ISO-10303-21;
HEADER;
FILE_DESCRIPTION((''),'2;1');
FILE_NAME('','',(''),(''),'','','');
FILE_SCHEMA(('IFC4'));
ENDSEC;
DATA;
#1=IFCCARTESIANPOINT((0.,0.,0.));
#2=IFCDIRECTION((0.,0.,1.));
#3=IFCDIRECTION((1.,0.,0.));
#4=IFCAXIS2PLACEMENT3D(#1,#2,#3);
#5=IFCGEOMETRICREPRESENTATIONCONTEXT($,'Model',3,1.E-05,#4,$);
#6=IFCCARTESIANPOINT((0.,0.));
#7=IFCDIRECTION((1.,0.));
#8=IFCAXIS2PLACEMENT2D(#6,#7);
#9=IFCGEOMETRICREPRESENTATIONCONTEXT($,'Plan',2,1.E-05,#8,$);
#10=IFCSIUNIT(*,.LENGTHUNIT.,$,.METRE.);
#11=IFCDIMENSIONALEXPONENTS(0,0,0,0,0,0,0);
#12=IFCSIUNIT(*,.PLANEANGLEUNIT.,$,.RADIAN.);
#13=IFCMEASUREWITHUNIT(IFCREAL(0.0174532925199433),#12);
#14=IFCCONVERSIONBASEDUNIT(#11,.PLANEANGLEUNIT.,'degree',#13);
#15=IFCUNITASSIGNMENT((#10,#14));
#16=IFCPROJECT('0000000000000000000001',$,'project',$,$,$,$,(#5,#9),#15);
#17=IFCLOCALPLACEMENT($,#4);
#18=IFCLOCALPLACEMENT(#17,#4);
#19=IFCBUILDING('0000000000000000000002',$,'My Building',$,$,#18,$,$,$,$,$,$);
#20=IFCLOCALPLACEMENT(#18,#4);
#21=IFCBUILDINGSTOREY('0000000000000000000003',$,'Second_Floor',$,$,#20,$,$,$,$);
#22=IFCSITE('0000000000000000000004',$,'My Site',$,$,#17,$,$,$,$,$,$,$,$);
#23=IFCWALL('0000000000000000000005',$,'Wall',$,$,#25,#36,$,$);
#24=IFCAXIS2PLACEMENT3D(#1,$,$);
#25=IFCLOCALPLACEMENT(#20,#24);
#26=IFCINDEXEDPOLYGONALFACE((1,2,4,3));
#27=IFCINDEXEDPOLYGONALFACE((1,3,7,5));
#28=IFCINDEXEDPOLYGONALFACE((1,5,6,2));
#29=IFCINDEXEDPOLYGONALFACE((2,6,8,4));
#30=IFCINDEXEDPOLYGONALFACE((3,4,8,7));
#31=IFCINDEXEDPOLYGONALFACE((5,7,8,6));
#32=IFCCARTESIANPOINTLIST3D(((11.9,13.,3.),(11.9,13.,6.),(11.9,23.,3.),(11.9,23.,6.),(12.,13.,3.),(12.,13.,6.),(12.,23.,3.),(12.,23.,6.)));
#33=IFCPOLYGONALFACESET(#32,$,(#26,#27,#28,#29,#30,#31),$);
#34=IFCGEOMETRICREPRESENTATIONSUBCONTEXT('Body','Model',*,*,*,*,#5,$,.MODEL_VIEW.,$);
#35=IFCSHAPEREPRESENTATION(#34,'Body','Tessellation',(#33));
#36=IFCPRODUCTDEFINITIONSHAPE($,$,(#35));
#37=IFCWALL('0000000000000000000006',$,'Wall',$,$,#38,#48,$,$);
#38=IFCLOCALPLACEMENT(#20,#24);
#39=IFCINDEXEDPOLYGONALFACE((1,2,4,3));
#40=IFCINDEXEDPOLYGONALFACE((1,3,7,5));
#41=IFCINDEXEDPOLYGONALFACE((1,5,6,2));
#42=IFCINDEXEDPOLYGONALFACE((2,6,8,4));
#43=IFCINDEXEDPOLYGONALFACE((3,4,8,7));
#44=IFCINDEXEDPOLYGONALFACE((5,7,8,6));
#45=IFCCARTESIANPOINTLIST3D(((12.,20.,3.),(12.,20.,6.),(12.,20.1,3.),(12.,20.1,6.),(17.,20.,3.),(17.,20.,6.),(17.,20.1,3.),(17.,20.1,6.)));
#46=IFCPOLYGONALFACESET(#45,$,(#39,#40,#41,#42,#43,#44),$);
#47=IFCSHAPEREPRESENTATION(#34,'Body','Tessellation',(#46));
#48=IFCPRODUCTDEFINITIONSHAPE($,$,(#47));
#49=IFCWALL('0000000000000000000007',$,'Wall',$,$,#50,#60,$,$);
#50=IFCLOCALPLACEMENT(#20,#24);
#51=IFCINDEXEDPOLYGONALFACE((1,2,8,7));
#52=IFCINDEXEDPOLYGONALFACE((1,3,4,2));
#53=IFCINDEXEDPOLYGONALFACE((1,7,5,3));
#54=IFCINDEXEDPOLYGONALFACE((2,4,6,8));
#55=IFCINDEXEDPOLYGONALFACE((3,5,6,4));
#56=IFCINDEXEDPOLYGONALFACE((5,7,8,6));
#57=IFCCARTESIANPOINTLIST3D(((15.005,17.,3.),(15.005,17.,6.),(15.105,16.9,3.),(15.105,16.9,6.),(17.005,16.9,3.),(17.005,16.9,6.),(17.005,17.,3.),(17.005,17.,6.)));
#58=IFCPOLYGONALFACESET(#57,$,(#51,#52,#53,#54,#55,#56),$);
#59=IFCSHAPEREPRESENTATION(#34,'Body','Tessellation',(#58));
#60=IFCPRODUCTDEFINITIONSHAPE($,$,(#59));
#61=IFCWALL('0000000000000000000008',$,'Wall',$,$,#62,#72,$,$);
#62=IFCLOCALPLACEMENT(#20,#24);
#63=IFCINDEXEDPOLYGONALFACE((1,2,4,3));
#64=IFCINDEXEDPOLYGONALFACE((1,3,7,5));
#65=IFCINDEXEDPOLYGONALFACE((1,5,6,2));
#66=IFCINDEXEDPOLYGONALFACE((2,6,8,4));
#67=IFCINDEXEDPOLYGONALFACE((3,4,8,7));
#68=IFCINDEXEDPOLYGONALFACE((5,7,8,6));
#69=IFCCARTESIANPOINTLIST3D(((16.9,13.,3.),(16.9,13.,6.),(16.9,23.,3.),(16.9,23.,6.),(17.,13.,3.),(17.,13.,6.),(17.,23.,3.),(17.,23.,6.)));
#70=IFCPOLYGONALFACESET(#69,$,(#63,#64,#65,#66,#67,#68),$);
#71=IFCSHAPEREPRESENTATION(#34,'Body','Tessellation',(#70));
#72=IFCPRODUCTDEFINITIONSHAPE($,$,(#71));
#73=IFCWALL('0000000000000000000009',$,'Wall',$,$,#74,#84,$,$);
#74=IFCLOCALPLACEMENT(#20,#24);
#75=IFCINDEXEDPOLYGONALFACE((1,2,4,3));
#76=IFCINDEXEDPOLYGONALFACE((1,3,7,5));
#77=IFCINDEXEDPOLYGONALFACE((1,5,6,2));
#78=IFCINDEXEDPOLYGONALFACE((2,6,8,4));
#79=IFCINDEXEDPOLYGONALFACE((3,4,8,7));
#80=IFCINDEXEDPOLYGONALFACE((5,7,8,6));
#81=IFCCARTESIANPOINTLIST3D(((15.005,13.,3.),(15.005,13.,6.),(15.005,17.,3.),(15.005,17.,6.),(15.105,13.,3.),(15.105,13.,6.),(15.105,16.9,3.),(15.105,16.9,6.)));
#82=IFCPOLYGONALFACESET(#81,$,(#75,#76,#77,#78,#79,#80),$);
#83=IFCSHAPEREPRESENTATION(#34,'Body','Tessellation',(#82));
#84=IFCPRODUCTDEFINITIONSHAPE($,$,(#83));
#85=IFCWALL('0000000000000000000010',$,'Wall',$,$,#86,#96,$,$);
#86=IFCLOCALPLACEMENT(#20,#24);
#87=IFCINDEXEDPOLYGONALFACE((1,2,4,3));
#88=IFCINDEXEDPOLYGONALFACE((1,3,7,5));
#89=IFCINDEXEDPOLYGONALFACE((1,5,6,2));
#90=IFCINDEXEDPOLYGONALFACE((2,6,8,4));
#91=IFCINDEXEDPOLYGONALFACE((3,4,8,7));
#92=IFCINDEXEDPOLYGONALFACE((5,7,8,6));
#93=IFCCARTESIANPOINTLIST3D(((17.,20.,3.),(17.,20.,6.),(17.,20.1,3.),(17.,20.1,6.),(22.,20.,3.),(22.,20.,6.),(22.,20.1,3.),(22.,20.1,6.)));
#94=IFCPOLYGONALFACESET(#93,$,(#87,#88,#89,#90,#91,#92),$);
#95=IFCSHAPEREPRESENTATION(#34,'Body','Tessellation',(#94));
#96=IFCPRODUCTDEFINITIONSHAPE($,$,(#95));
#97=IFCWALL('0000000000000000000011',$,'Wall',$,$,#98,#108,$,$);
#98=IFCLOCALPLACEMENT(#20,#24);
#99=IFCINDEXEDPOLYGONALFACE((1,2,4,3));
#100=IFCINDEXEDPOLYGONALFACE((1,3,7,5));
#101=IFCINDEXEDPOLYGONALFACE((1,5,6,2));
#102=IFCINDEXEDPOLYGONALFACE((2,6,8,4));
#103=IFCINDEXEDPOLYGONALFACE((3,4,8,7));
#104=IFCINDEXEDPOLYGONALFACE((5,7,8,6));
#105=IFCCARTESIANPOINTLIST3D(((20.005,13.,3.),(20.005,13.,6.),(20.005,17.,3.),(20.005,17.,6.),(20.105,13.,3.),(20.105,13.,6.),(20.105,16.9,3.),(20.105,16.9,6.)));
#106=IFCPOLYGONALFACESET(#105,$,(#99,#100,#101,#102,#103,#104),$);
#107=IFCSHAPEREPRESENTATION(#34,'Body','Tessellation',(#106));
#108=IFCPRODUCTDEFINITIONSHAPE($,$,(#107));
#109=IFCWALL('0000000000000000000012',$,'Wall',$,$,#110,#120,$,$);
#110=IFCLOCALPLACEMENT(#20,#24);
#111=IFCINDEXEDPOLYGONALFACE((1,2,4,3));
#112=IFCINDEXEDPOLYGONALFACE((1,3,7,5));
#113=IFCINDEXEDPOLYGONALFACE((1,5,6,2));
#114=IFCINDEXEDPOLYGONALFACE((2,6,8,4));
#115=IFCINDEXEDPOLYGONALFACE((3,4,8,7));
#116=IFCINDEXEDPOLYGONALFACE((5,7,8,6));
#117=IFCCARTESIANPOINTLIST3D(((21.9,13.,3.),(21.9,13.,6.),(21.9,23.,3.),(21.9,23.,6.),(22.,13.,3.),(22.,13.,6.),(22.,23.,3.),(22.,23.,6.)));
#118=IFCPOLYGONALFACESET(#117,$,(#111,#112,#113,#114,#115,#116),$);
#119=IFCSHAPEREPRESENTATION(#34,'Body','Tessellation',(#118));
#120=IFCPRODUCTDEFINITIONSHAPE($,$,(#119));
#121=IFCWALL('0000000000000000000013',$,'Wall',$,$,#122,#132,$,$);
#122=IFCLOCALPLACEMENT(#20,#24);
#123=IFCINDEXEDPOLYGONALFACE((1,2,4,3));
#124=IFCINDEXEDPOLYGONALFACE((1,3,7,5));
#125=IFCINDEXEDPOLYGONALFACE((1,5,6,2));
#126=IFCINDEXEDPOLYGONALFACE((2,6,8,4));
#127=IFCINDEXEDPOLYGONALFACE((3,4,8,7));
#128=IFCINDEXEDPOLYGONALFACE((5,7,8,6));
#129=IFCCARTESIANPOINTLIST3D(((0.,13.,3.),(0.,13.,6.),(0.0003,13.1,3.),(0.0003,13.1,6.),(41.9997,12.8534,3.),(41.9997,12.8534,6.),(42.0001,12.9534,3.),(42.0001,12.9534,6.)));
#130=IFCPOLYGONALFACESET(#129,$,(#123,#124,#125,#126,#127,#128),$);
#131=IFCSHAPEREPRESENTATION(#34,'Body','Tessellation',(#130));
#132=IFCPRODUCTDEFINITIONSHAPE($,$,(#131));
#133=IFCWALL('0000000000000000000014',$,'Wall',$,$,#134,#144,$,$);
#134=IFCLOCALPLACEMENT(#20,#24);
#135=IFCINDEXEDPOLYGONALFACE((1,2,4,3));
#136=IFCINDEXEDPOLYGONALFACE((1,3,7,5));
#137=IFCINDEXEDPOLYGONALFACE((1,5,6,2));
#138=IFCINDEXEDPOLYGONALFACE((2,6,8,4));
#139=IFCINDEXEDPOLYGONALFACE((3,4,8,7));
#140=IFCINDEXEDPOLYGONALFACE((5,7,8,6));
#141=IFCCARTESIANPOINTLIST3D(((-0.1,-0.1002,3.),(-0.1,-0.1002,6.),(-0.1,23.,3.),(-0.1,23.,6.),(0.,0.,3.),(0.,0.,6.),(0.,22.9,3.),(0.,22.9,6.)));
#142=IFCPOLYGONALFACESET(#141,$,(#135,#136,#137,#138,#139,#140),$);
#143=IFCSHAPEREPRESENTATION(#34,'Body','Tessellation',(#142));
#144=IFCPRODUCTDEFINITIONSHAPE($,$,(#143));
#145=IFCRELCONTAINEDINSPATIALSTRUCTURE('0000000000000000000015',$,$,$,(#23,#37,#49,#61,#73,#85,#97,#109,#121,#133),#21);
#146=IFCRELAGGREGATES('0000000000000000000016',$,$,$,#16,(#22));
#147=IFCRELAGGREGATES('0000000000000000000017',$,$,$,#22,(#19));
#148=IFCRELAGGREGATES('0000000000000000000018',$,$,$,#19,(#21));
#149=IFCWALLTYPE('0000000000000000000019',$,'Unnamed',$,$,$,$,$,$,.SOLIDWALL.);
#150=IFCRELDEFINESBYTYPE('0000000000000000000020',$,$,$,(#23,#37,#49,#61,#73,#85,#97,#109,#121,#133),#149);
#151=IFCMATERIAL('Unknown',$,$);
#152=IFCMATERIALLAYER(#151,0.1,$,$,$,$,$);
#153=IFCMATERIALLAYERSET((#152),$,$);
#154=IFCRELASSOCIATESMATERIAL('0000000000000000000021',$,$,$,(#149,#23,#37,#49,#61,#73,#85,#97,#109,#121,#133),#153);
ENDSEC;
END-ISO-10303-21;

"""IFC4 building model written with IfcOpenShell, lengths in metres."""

from ifc_helpers import new_model, entity, si_unit, converted_unit, frame, origin_with_axes, origin_2d_with_axis, place, context, subcontext, project, spatial, line, indexed_curve, outline, extrude, material, layer, layer_set, layer_usage, type_object, element, save


model = new_model("IFC4")

# Units and contexts
model_context = context("Model", 3, precision=1e-05, world=origin_with_axes())
plan_context = context("Plan", 2, precision=1e-05, world=origin_2d_with_axis())
body_context = subcontext(model_context, "Body", "Model", "MODEL_VIEW")
ifc_project = project(units=[si_unit("LENGTHUNIT", "METRE"), converted_unit("PLANEANGLEUNIT", "degree", entity("IfcReal", 0.0174532925199433), si_unit("PLANEANGLEUNIT", "RADIAN"), dimensions=[0, 0, 0, 0, 0, 0, 0])], contexts=[model_context, plan_context])

# Site, building, storey
site_placement = place(None, origin_with_axes())
site = spatial("IfcSite", under=ifc_project, at=site_placement, Name="My Site")
building_placement = place(site_placement, origin_with_axes())
building = spatial("IfcBuilding", under=site, at=building_placement, Name="My Building")
storey_placement = place(building_placement, origin_with_axes())
storey = spatial("IfcBuildingStorey", under=building, at=storey_placement, Name="Second_Floor")

# Shared definitions
ifc_material = material(Name="Unknown")

# Walls
ifc_layer_1 = layer(ifc_material, 0.1)
ifc_layer_set_1 = layer_set([ifc_layer_1])
wall_type = type_object("IfcWallType", Name="Unnamed", PredefinedType="SOLIDWALL", material=ifc_layer_set_1)
ifc_layer_usage_1 = layer_usage(ifc_layer_set_1, "AXIS2", "POSITIVE", 0.0)
wall_1_placement = place(storey_placement, frame((11.9, 23.0, 3.0), z_axis=(0.0, 0.0, 1.0), x_axis=(0.0, -1.0, 0.0)))
element("IfcWall", 1, at=wall_1_placement, inside=storey, type_object=wall_type, material=ifc_layer_usage_1, Name="Wall", context=body_context, shape_type="SweptSolid", body=[
    extrude(outline(indexed_curve([(0.0, 0.0), (0.0, 0.1), (10.0, 0.1), (10.0, 0.0)], segments=[line(1, 2, 3, 4, 1)])), origin_with_axes(), (0.0, 0.0, 1.0), 3.0),
])
ifc_layer_usage_2 = layer_usage(ifc_layer_set_1, "AXIS2", "POSITIVE", 0.0)
wall_2_placement = place(storey_placement, frame((12.0, 20.0, 3.0), z_axis=(0.0, 0.0, 1.0), x_axis=(1.0, 0.0, 0.0)))
element("IfcWall", 2, at=wall_2_placement, inside=storey, type_object=wall_type, material=ifc_layer_usage_2, Name="Wall", context=body_context, shape_type="SweptSolid", body=[
    extrude(outline(indexed_curve([(0.0, 0.0), (0.0, 0.1), (5.0, 0.1), (5.0, 0.0)], segments=[line(1, 2, 3, 4, 1)])), origin_with_axes(), (0.0, 0.0, 1.0), 3.0),
])
ifc_layer_usage_3 = layer_usage(ifc_layer_set_1, "AXIS2", "POSITIVE", 0.0)
wall_3_placement = place(storey_placement, frame((17.005, 17.0, 3.0), z_axis=(0.0, 0.0, 1.0), x_axis=(-1.0, 0.0, 0.0)))
element("IfcWall", 3, at=wall_3_placement, inside=storey, type_object=wall_type, material=ifc_layer_usage_3, Name="Wall", context=body_context, shape_type="SweptSolid", body=[
    extrude(outline(indexed_curve([(0.0, 0.0), (0.0, 0.1), (1.9, 0.1), (2.0, 0.0)], segments=[line(1, 2, 3, 4, 1)])), origin_with_axes(), (0.0, 0.0, 1.0), 3.0),
])
ifc_layer_usage_4 = layer_usage(ifc_layer_set_1, "AXIS2", "POSITIVE", 0.0)
wall_4_placement = place(storey_placement, frame((16.9, 23.0, 3.0), z_axis=(0.0, 0.0, 1.0), x_axis=(0.0, -1.0, 0.0)))
element("IfcWall", 4, at=wall_4_placement, inside=storey, type_object=wall_type, material=ifc_layer_usage_4, Name="Wall", context=body_context, shape_type="SweptSolid", body=[
    extrude(outline(indexed_curve([(0.0, 0.0), (0.0, 0.1), (10.0, 0.1), (10.0, 0.0)], segments=[line(1, 2, 3, 4, 1)])), origin_with_axes(), (0.0, 0.0, 1.0), 3.0),
])
ifc_layer_usage_5 = layer_usage(ifc_layer_set_1, "AXIS2", "POSITIVE", 0.0)
wall_5_placement = place(storey_placement, frame((15.005, 17.0, 3.0), z_axis=(0.0, 0.0, 1.0), x_axis=(0.0, -1.0, 0.0)))
element("IfcWall", 5, at=wall_5_placement, inside=storey, type_object=wall_type, material=ifc_layer_usage_5, Name="Wall", context=body_context, shape_type="SweptSolid", body=[
    extrude(outline(indexed_curve([(0.0, 0.0), (0.1, 0.1), (4.0, 0.1), (4.0, 0.0)], segments=[line(1, 2, 3, 4, 1)])), origin_with_axes(), (0.0, 0.0, 1.0), 3.0),
])
ifc_layer_usage_6 = layer_usage(ifc_layer_set_1, "AXIS2", "POSITIVE", 0.0)
wall_6_placement = place(storey_placement, frame((17.0, 20.0, 3.0), z_axis=(0.0, 0.0, 1.0), x_axis=(1.0, 0.0, 0.0)))
element("IfcWall", 6, at=wall_6_placement, inside=storey, type_object=wall_type, material=ifc_layer_usage_6, Name="Wall", context=body_context, shape_type="SweptSolid", body=[
    extrude(outline(indexed_curve([(0.0, 0.0), (0.0, 0.1), (5.0, 0.1), (5.0, 0.0)], segments=[line(1, 2, 3, 4, 1)])), origin_with_axes(), (0.0, 0.0, 1.0), 3.0),
])
ifc_layer_usage_7 = layer_usage(ifc_layer_set_1, "AXIS2", "POSITIVE", 0.0)
wall_7_placement = place(storey_placement, frame((20.005, 17.0, 3.0), z_axis=(0.0, 0.0, 1.0), x_axis=(0.0, -1.0, 0.0)))
element("IfcWall", 7, at=wall_7_placement, inside=storey, type_object=wall_type, material=ifc_layer_usage_7, Name="Wall", context=body_context, shape_type="SweptSolid", body=[
    extrude(outline(indexed_curve([(0.0, 0.0), (0.1, 0.1), (4.0, 0.1), (4.0, 0.0)], segments=[line(1, 2, 3, 4, 1)])), origin_with_axes(), (0.0, 0.0, 1.0), 3.0),
])
ifc_layer_usage_8 = layer_usage(ifc_layer_set_1, "AXIS2", "POSITIVE", 0.0)
wall_8_placement = place(storey_placement, frame((21.9, 23.0, 3.0), z_axis=(0.0, 0.0, 1.0), x_axis=(0.0, -1.0, 0.0)))
element("IfcWall", 8, at=wall_8_placement, inside=storey, type_object=wall_type, material=ifc_layer_usage_8, Name="Wall", context=body_context, shape_type="SweptSolid", body=[
    extrude(outline(indexed_curve([(0.0, 0.0), (0.0, 0.1), (10.0, 0.1), (10.0, 0.0)], segments=[line(1, 2, 3, 4, 1)])), origin_with_axes(), (0.0, 0.0, 1.0), 3.0),
])
ifc_layer_usage_9 = layer_usage(ifc_layer_set_1, "AXIS2", "POSITIVE", 0.0)
wall_9_placement = place(storey_placement, frame((0.0, 13.0, 3.0), z_axis=(0.0, 0.0, 1.0), x_axis=(0.999994, -0.003491, 0.0)))
element("IfcWall", 9, at=wall_9_placement, inside=storey, type_object=wall_type, material=ifc_layer_usage_9, Name="Wall", context=body_context, shape_type="SweptSolid", body=[
    extrude(outline(indexed_curve([(0.0, 0.0), (0.0, 0.1), (42.0, 0.1), (42.0, 0.0)], segments=[line(1, 2, 3, 4, 1)])), origin_with_axes(), (0.0, 0.0, 1.0), 3.0),
])
ifc_layer_usage_10 = layer_usage(ifc_layer_set_1, "AXIS2", "POSITIVE", 0.0)
wall_10_placement = place(storey_placement, frame((0.0, 0.0, 3.0), z_axis=(0.0, 0.0, 1.0), x_axis=(0.0, 1.0, 0.0)))
element("IfcWall", 10, at=wall_10_placement, inside=storey, type_object=wall_type, material=ifc_layer_usage_10, Name="Wall", context=body_context, shape_type="SweptSolid", body=[
    extrude(outline(indexed_curve([(0.0, 0.0), (-0.1002, 0.1), (23.0, 0.1), (22.9, 0.0)], segments=[line(1, 2, 3, 4, 1)])), origin_with_axes(), (0.0, 0.0, 1.0), 3.0),
])

save(model, "model.ifc")
